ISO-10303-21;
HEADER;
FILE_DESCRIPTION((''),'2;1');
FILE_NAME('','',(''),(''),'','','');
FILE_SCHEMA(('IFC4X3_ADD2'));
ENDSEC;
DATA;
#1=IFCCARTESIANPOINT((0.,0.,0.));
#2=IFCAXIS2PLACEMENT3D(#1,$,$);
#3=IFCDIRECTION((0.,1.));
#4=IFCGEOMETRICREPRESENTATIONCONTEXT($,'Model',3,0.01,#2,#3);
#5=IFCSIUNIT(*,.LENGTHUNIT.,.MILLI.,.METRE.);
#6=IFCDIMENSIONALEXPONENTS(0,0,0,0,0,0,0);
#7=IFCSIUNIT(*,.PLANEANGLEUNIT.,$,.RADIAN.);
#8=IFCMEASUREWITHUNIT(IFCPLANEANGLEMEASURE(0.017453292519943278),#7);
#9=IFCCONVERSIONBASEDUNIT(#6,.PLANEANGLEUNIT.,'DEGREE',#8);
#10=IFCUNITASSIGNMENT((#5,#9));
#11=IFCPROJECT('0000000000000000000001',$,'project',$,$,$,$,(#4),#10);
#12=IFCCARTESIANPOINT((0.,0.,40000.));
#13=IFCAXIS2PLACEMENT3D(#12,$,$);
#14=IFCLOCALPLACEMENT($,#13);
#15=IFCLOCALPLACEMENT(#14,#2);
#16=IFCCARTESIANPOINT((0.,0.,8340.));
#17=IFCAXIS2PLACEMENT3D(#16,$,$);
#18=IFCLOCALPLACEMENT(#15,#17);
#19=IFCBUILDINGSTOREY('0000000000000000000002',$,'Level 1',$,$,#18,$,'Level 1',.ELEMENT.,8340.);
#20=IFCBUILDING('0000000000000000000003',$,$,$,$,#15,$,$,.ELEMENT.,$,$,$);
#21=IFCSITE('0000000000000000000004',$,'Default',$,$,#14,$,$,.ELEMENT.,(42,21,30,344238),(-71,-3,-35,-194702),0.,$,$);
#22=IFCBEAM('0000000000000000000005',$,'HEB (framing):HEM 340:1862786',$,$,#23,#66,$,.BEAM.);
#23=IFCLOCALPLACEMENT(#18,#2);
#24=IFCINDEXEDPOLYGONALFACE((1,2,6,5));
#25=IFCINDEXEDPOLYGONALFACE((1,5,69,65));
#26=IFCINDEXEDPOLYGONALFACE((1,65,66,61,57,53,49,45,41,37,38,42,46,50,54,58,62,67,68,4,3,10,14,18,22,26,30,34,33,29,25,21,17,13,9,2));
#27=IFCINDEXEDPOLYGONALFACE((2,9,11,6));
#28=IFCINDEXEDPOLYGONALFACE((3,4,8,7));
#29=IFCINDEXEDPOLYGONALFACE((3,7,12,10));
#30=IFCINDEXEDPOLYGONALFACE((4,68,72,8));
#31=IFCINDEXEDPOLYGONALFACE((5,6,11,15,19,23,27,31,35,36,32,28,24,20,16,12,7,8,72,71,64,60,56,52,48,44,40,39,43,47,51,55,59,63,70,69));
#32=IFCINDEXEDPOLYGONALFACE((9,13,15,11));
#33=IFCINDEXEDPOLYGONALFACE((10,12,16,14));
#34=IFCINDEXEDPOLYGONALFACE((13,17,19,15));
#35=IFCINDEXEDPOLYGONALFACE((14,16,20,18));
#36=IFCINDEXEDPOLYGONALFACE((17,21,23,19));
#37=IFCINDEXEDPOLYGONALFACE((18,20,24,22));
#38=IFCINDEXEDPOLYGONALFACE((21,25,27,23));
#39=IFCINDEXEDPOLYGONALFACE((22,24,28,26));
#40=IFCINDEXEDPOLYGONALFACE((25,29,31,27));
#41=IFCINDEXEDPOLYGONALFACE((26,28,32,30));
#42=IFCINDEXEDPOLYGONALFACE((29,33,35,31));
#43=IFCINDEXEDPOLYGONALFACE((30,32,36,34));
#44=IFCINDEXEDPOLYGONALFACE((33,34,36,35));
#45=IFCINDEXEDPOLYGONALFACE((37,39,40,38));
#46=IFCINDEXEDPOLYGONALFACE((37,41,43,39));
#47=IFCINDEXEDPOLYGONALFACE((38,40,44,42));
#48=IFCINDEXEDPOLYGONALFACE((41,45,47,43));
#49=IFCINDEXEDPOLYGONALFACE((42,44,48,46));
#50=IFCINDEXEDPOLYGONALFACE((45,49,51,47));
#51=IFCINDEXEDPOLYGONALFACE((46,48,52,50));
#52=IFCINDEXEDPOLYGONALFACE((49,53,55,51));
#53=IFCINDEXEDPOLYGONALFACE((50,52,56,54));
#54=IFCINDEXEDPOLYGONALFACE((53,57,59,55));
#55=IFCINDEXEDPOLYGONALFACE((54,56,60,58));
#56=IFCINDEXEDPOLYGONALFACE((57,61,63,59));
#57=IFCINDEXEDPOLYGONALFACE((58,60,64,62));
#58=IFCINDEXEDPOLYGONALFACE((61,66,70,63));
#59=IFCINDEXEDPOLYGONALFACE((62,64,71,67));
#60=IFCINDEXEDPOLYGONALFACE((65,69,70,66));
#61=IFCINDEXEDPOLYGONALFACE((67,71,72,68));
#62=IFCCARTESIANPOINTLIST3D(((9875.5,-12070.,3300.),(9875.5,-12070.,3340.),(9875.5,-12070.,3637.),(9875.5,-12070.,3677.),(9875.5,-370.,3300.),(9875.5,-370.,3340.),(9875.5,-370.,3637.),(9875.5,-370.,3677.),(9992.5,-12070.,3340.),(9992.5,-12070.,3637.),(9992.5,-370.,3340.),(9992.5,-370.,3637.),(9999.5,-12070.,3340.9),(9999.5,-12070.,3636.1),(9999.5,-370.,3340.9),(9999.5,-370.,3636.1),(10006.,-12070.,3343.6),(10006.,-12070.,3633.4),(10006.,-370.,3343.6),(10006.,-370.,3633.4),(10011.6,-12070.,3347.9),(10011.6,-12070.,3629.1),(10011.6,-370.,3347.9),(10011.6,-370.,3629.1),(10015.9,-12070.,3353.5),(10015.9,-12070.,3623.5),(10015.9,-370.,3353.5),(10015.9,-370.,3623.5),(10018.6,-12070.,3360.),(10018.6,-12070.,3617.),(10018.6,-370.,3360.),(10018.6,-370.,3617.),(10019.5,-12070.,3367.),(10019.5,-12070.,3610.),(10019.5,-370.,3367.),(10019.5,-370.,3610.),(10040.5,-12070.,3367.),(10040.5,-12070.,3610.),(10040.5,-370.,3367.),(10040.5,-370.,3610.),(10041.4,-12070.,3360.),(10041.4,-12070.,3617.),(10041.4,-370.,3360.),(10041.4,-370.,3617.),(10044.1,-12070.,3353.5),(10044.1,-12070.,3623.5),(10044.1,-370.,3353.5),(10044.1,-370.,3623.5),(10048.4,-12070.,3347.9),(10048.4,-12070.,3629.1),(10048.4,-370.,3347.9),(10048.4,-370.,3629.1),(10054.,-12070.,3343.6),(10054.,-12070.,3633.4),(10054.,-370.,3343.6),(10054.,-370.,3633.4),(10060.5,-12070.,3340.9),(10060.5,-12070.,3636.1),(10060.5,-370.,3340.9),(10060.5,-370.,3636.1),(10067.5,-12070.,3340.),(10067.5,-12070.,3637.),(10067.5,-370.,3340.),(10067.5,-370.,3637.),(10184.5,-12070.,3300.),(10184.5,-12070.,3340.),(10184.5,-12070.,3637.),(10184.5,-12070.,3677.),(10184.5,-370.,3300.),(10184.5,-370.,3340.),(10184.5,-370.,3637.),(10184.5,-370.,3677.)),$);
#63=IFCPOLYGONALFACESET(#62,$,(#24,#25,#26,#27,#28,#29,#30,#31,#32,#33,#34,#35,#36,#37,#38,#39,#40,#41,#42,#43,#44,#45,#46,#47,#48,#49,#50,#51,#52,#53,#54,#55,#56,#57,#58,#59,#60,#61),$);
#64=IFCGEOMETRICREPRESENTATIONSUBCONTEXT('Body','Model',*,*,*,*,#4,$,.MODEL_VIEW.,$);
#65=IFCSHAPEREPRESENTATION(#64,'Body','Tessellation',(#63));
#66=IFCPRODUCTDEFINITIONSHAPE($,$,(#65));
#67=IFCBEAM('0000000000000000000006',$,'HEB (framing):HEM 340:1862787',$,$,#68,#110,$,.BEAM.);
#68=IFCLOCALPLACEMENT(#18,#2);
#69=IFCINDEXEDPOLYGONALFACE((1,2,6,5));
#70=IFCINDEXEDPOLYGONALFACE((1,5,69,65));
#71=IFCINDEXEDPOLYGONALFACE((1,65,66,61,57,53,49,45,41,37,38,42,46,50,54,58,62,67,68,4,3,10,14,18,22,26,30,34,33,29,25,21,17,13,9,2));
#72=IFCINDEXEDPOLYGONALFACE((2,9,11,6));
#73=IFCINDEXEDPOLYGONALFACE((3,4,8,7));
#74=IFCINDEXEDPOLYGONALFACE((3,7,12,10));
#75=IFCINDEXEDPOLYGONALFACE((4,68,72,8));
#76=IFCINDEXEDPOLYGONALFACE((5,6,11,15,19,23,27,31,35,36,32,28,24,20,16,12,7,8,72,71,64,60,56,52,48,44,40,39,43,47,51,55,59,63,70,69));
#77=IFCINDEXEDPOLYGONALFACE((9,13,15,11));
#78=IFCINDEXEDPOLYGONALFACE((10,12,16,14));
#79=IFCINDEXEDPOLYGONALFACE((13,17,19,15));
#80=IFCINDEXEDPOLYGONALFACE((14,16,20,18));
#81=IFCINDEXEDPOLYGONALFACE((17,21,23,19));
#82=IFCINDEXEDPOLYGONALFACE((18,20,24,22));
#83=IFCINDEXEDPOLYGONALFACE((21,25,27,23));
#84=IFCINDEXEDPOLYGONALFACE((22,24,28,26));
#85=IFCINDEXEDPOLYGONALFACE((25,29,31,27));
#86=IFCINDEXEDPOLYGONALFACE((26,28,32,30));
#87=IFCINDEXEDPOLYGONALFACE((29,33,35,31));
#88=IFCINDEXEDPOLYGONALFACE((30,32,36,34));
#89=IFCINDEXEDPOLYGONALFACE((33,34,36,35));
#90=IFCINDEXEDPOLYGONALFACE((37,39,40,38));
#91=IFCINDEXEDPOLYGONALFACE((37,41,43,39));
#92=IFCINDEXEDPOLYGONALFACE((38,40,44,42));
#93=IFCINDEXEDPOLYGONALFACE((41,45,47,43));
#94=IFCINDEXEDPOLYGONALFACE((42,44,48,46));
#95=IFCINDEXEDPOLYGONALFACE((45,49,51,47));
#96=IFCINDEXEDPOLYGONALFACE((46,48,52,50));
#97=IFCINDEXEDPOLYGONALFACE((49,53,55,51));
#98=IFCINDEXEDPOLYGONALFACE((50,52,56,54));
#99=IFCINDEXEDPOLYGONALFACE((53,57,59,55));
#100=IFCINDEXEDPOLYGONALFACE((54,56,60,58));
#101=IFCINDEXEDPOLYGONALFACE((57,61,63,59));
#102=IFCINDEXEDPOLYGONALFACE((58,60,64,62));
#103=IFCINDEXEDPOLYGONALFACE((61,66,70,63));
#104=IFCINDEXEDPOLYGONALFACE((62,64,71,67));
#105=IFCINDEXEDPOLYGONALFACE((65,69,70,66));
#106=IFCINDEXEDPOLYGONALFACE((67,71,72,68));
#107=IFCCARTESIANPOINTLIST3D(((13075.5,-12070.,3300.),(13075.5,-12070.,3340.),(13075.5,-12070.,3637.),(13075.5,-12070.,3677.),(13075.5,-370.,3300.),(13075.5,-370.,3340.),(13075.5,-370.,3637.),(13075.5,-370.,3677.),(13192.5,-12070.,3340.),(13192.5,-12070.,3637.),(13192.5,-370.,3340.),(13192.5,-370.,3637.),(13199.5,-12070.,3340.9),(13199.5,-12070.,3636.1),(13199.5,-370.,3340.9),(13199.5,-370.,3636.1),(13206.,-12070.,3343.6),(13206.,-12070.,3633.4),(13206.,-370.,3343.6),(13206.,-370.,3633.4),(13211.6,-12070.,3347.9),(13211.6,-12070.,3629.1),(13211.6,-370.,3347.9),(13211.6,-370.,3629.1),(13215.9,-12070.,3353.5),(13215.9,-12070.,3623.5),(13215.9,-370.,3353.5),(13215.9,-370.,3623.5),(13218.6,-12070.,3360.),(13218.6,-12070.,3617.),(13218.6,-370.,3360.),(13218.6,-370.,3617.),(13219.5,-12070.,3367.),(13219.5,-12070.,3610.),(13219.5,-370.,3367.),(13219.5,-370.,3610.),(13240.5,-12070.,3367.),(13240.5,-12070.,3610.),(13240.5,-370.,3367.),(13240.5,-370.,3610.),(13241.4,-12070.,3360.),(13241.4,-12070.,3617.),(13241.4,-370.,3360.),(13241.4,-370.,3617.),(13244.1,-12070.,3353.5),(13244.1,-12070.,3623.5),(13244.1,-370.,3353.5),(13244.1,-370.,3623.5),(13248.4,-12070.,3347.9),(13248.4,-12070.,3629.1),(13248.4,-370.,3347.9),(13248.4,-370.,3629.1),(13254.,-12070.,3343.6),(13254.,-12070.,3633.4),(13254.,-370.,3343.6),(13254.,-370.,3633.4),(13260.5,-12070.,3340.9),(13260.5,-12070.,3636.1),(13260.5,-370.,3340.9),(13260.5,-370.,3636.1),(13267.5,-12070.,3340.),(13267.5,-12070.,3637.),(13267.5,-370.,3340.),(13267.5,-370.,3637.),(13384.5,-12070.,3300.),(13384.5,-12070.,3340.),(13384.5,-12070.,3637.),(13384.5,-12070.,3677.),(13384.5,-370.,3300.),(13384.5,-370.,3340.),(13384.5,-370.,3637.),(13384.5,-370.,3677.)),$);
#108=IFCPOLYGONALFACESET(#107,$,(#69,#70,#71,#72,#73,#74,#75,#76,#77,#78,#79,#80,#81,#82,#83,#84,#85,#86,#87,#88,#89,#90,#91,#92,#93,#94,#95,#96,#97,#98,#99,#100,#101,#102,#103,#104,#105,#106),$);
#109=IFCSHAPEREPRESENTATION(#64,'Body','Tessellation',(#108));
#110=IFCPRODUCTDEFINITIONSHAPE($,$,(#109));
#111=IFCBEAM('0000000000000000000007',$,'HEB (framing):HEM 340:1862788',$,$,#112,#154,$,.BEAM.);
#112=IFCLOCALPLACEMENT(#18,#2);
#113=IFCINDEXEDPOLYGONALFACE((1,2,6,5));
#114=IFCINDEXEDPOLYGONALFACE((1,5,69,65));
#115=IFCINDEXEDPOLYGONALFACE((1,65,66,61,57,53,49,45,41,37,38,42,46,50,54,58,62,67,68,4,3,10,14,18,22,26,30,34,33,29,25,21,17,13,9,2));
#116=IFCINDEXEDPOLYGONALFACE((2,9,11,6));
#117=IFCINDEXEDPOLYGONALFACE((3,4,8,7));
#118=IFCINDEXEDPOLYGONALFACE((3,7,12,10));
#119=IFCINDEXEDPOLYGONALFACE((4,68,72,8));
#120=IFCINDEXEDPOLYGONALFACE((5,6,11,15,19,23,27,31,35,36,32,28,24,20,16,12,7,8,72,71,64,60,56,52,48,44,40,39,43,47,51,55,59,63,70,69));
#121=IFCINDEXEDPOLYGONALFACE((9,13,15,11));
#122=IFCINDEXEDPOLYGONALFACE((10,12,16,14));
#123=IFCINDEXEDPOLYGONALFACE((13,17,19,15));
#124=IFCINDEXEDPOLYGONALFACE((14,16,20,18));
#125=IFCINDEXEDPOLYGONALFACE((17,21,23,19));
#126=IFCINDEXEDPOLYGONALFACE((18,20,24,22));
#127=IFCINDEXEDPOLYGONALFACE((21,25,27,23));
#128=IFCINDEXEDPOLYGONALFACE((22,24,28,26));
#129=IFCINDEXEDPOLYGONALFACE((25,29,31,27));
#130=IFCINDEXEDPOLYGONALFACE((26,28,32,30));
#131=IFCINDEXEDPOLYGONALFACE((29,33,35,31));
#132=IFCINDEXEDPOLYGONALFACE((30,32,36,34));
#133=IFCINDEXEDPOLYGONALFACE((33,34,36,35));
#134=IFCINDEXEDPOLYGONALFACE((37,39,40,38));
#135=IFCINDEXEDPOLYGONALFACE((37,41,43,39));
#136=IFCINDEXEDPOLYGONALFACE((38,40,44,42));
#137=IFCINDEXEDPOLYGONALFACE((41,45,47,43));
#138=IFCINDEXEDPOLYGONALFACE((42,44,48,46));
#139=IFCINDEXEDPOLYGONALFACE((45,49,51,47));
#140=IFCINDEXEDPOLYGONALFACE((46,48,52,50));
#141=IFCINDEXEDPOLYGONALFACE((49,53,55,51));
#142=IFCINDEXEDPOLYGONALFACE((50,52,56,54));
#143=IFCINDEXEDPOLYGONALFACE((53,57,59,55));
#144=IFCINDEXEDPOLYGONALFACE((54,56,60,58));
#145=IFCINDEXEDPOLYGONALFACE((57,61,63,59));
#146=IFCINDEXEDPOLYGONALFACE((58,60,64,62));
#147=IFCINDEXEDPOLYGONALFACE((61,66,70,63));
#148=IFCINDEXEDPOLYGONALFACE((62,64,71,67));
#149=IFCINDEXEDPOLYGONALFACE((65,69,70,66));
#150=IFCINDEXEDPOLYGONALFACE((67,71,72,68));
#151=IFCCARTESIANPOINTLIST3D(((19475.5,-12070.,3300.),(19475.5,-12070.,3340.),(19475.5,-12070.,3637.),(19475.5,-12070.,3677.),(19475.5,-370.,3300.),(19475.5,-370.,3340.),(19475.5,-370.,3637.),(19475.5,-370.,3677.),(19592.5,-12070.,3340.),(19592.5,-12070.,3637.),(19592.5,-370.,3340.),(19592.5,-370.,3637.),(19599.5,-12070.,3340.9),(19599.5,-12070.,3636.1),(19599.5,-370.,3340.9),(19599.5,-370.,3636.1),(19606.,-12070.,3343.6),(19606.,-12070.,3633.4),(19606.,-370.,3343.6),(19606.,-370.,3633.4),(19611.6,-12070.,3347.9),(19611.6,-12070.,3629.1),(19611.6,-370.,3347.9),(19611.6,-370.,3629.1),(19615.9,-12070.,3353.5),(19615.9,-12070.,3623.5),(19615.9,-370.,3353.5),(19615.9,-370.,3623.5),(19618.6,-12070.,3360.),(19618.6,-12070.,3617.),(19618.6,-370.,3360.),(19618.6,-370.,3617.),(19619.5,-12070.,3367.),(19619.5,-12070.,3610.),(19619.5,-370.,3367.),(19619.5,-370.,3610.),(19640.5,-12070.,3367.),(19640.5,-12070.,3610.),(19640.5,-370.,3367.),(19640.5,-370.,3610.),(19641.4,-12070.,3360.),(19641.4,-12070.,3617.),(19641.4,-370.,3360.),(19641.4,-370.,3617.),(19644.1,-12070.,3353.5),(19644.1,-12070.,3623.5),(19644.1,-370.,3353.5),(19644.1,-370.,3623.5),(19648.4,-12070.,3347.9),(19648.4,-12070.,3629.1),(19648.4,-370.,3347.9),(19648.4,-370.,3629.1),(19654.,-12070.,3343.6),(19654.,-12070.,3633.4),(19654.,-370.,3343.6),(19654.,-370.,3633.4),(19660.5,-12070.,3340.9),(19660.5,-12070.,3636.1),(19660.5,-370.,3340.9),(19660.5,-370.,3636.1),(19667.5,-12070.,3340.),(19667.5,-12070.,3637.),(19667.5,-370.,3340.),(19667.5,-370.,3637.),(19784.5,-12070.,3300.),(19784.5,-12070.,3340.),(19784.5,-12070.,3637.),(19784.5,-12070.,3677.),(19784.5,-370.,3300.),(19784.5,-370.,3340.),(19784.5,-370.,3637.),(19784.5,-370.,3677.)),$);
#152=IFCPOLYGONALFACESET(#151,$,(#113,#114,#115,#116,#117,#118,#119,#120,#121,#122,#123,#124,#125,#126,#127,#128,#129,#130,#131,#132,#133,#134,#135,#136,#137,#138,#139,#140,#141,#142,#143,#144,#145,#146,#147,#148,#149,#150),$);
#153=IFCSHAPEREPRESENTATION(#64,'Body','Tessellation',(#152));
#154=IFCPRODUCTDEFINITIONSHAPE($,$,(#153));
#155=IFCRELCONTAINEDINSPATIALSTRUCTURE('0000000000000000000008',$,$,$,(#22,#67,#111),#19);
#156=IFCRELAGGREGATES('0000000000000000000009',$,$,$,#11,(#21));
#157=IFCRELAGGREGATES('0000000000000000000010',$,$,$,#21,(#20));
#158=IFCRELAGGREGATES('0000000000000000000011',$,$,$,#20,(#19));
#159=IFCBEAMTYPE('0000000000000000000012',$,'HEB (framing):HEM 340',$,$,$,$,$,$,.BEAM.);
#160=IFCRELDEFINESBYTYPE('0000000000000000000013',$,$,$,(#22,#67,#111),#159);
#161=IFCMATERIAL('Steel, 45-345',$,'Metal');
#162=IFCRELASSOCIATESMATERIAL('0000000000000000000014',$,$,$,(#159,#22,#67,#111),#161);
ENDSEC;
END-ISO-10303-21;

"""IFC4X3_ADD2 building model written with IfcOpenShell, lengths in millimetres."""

from ifc_helpers import new_model, entity, si_unit, converted_unit, direction, frame, frame_2d, origin, place, context, subcontext, project, spatial, polyline, circle_curve, parameter, trimmed, segment, composite_curve, outline, extrude, source, transform, mapped, material, material_profile, profile_set, profile_usage, type_object, type_shapes, element, save


model = new_model("IFC4X3_ADD2")

# Units and contexts
model_context = context("Model", 3, precision=0.01, world=origin(), true_north=direction((0.0, 1.0)))
body_context = subcontext(model_context, "Body", "Model", "MODEL_VIEW")
ifc_project = project(units=[si_unit("LENGTHUNIT", "METRE", prefix="MILLI"), converted_unit("PLANEANGLEUNIT", "DEGREE", entity("IfcPlaneAngleMeasure", 0.017453292519943278), si_unit("PLANEANGLEUNIT", "RADIAN"), dimensions=[0, 0, 0, 0, 0, 0, 0])], contexts=[model_context])

# Site, building, storey
site_placement = place(None, frame((0.0, 0.0, 40000.0)))
site = spatial("IfcSite", under=ifc_project, at=site_placement, Name="Default", CompositionType="ELEMENT", RefLatitude=(42, 21, 30, 344238), RefLongitude=(-71, -3, -35, -194702), RefElevation=0.0)
building_placement = place(site_placement, origin())
building = spatial("IfcBuilding", under=site, at=building_placement, CompositionType="ELEMENT")
storey_placement = place(building_placement, frame((0.0, 0.0, 8340.0)))
storey = spatial("IfcBuildingStorey", under=building, at=storey_placement, Name="Level 1", LongName="Level 1", CompositionType="ELEMENT", Elevation=8340.0)

# Shared definitions
ifc_material_1 = material(Name="Steel, 45-345", Category="Metal")

# Beams
ifc_material_profile_1 = material_profile(ifc_material_1, outline(composite_curve([segment(polyline([(-154.5, -148.5), (-154.5, -188.5)]), True, "CONTINUOUS"), segment(polyline([(-154.5, -188.5), (154.5, -188.5)]), True, "CONTINUOUS"), segment(polyline([(154.5, -188.5), (154.5, -148.5)]), True, "CONTINUOUS"), segment(polyline([(154.5, -148.5), (37.5, -148.5)]), True, "CONTINUOUS"), segment(trimmed(circle_curve(frame_2d((37.5, -121.5), x_axis=(1.0, 0.0)), 27.0), [parameter(180.0)], [parameter(270.0)], True, "PARAMETER"), False, "CONTINUOUS"), segment(polyline([(10.5, -121.5), (10.5, 121.5)]), True, "CONTINUOUS"), segment(trimmed(circle_curve(frame_2d((37.5, 121.5), x_axis=(1.0, 0.0)), 27.0), [parameter(90.0)], [parameter(180.0)], True, "PARAMETER"), False, "CONTINUOUS"), segment(polyline([(37.5, 148.5), (154.5, 148.5)]), True, "CONTINUOUS"), segment(polyline([(154.5, 148.5), (154.5, 188.5)]), True, "CONTINUOUS"), segment(polyline([(154.5, 188.5), (-154.5, 188.5)]), True, "CONTINUOUS"), segment(polyline([(-154.5, 188.5), (-154.5, 148.5)]), True, "CONTINUOUS"), segment(polyline([(-154.5, 148.5), (-37.5, 148.5)]), True, "CONTINUOUS"), segment(trimmed(circle_curve(frame_2d((-37.5, 121.5), x_axis=(1.0, 0.0)), 27.0), [parameter(360.0)], [parameter(90.0)], True, "PARAMETER"), False, "CONTINUOUS"), segment(polyline([(-10.5, 121.5), (-10.5, -121.5)]), True, "CONTINUOUS"), segment(trimmed(circle_curve(frame_2d((-37.5, -121.5), x_axis=(1.0, 0.0)), 27.0), [parameter(270.0)], [parameter(0.0)], True, "PARAMETER"), False, "CONTINUOUS"), segment(polyline([(-37.5, -148.5), (-154.5, -148.5)]), True, "CONTINUOUS")], self_intersect=False)), Name="HEM 340")
ifc_profile_set_1 = profile_set([ifc_material_profile_1], Name="HEM 340")
ifc_profile_usage_1 = profile_usage(ifc_profile_set_1, cardinal=8)
beam_type_1 = type_object("IfcBeamType", Name="HEB (framing):HEM 340", PredefinedType="BEAM", material=ifc_profile_set_1)
shared_shape_1 = source(origin(), body_context, "Body", "SweptSolid", [
    extrude(outline(composite_curve([segment(polyline([(-154.5, -148.5), (-154.5, -188.5)]), True, "CONTINUOUS"), segment(polyline([(-154.5, -188.5), (154.5, -188.5)]), True, "CONTINUOUS"), segment(polyline([(154.5, -188.5), (154.5, -148.5)]), True, "CONTINUOUS"), segment(polyline([(154.5, -148.5), (37.5, -148.5)]), True, "CONTINUOUS"), segment(trimmed(circle_curve(frame_2d((37.5, -121.5), x_axis=(1.0, 0.0)), 27.0), [parameter(180.0)], [parameter(270.0)], True, "PARAMETER"), False, "CONTINUOUS"), segment(polyline([(10.5, -121.5), (10.5, 121.5)]), True, "CONTINUOUS"), segment(trimmed(circle_curve(frame_2d((37.5, 121.5), x_axis=(1.0, 0.0)), 27.0), [parameter(90.0)], [parameter(180.0)], True, "PARAMETER"), False, "CONTINUOUS"), segment(polyline([(37.5, 148.5), (154.5, 148.5)]), True, "CONTINUOUS"), segment(polyline([(154.5, 148.5), (154.5, 188.5)]), True, "CONTINUOUS"), segment(polyline([(154.5, 188.5), (-154.5, 188.5)]), True, "CONTINUOUS"), segment(polyline([(-154.5, 188.5), (-154.5, 148.5)]), True, "CONTINUOUS"), segment(polyline([(-154.5, 148.5), (-37.5, 148.5)]), True, "CONTINUOUS"), segment(trimmed(circle_curve(frame_2d((-37.5, 121.5), x_axis=(1.0, 0.0)), 27.0), [parameter(360.0)], [parameter(90.0)], True, "PARAMETER"), False, "CONTINUOUS"), segment(polyline([(-10.5, 121.5), (-10.5, -121.5)]), True, "CONTINUOUS"), segment(trimmed(circle_curve(frame_2d((-37.5, -121.5), x_axis=(1.0, 0.0)), 27.0), [parameter(270.0)], [parameter(0.0)], True, "PARAMETER"), False, "CONTINUOUS"), segment(polyline([(-37.5, -148.5), (-154.5, -148.5)]), True, "CONTINUOUS")], self_intersect=False)), frame((-5850.0, 0.0, 0.0), z_axis=(-1.0, 0.0, 0.0), x_axis=(0.0, -1.0, 0.0)), (0.0, 0.0, -1.0), 11700.0),
])
type_shapes(beam_type_1, [shared_shape_1])
for number, where, z_axis, x_axis, name in (
    (1, (10030.0, -6220.0, 3488.5), (0.0, 0.0, 1.0), (0.0, -1.0, 0.0), "HEB (framing):HEM 340:1862786"),
    (2, (13230.0, -6220.0, 3488.5), (0.0, 0.0, 1.0), (0.0, -1.0, 0.0), "HEB (framing):HEM 340:1862787"),
    (3, (19630.0, -6220.0, 3488.5), (0.0, 0.0, 1.0), (0.0, -1.0, 0.0), "HEB (framing):HEM 340:1862788"),
):
    element("IfcBeam", number, at=place(storey_placement, frame(where, z_axis=z_axis, x_axis=x_axis)), inside=storey, type_object=beam_type_1, material=ifc_profile_usage_1, Name=name, PredefinedType="BEAM", context=body_context, shape_type="MappedRepresentation", body=[
        mapped(shared_shape_1, transform((0.0, 0.0, 0.0), scale=1.0)),
    ])

save(model, "model.ifc")
